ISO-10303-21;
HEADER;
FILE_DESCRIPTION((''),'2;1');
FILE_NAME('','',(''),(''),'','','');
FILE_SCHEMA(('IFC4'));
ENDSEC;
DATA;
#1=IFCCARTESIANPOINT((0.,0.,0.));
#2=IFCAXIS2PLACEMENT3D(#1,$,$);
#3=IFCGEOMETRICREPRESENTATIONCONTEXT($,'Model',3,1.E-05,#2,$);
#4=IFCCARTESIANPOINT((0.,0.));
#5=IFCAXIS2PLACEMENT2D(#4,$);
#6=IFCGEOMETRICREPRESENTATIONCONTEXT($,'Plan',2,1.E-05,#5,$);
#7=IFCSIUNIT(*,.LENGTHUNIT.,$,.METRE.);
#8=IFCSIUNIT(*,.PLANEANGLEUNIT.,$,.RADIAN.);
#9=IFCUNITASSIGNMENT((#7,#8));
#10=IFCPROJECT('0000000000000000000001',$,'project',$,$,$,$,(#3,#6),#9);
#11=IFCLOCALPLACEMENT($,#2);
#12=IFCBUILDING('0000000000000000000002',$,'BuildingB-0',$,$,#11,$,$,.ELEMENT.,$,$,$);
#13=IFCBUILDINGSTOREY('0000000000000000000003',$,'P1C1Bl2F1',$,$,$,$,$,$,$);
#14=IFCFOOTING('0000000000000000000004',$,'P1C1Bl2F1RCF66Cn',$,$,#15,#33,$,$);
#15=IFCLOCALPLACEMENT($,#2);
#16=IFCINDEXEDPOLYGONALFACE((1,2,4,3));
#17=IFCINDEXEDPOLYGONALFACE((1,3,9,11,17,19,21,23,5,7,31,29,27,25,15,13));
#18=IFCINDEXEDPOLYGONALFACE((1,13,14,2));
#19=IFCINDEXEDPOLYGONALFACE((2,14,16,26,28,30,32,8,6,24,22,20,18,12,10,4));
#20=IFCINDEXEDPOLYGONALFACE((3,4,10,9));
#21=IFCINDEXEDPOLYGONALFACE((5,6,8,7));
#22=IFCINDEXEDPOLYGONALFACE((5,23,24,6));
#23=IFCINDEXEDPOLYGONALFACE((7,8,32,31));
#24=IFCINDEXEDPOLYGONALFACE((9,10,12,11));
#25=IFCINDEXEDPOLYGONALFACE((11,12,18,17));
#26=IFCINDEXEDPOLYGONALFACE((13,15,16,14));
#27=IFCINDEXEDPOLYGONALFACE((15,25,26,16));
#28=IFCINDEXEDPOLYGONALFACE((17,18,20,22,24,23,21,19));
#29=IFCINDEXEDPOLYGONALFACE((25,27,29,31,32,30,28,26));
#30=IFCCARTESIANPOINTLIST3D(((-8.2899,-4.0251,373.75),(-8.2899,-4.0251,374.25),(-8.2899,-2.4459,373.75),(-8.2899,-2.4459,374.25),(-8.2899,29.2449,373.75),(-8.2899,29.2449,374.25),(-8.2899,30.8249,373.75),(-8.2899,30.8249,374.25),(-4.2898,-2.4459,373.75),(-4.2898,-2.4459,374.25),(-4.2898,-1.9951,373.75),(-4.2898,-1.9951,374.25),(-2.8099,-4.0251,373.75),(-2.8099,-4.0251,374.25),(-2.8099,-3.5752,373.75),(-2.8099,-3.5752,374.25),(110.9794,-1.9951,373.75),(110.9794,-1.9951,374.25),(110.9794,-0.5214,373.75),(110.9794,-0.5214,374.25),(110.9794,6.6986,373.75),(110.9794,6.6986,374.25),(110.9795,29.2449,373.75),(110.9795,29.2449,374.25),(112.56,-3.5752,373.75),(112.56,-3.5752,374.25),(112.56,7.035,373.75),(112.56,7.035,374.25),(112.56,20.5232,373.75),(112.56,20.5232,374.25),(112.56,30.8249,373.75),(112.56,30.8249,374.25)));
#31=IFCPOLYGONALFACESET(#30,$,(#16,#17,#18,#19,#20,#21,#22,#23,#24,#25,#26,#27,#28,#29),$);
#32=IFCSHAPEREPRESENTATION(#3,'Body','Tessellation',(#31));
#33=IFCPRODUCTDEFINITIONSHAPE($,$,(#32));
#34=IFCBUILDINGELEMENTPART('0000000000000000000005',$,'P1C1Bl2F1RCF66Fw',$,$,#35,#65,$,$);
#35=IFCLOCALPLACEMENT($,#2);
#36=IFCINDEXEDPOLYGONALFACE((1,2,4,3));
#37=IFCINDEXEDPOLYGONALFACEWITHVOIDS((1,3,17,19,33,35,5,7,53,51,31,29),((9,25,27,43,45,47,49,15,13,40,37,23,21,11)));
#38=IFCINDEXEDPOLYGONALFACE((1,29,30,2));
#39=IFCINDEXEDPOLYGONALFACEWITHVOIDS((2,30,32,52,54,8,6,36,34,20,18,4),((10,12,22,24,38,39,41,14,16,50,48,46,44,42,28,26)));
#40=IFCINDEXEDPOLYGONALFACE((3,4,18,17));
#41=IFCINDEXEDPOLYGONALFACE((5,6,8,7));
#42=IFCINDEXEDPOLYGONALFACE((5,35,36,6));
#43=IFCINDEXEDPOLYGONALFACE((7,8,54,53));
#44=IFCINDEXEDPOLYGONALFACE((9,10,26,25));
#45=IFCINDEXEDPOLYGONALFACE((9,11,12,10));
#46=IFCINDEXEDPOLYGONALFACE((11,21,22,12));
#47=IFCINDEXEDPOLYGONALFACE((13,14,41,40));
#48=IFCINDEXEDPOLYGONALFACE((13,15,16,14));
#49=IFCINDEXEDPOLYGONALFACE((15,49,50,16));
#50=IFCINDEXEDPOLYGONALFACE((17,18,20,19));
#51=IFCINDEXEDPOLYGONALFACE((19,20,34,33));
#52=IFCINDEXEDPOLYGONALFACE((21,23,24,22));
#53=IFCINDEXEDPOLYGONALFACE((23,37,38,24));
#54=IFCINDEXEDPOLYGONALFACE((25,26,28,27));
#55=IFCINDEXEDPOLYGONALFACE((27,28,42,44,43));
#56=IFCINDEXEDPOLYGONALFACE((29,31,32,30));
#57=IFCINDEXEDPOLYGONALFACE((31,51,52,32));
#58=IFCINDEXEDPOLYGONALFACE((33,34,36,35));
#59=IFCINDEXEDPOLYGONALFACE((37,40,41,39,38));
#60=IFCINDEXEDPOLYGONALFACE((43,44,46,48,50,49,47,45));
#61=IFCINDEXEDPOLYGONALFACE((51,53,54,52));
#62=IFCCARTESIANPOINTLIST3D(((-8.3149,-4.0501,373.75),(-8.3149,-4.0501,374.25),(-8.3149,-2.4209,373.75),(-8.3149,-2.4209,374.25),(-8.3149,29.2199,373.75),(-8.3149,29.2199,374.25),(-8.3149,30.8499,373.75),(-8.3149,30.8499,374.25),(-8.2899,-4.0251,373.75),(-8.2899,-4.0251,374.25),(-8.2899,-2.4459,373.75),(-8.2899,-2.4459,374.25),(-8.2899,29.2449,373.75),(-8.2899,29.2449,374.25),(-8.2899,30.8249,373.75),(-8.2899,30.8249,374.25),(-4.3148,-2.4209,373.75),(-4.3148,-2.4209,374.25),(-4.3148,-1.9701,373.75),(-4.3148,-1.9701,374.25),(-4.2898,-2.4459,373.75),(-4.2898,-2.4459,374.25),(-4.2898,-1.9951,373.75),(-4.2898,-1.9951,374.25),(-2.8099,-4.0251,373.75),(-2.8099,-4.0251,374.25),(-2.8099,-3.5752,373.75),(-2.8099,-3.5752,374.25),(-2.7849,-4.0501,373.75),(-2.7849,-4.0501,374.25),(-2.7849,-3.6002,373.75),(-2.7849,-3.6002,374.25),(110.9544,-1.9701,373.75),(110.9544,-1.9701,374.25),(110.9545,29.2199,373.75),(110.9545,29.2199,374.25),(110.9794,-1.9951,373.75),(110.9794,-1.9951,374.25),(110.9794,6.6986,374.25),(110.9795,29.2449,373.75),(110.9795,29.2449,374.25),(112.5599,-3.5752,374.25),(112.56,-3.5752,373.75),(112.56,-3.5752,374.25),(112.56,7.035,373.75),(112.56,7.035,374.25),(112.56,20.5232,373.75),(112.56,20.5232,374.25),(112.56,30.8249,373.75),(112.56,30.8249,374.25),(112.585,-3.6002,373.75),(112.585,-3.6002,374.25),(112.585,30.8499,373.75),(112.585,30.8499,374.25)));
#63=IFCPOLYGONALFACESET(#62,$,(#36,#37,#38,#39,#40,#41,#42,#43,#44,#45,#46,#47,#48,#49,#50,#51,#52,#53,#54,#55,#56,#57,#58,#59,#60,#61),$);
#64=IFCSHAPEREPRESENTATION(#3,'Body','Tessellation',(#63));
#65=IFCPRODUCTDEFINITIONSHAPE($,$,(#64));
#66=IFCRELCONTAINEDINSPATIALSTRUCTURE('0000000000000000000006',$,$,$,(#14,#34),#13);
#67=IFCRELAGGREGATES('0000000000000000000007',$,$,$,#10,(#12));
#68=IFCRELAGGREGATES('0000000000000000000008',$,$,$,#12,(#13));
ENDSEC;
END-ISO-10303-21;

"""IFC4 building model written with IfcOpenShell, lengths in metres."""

from ifc_helpers import new_model, si_unit, origin, origin_2d, place, context, project, spatial, polyline, outline, extrude, element, save


model = new_model("IFC4")

# Units and contexts
model_context = context("Model", 3, precision=1e-05, world=origin())
plan_context = context("Plan", 2, precision=1e-05, world=origin_2d())
ifc_project = project(units=[si_unit("LENGTHUNIT", "METRE"), si_unit("PLANEANGLEUNIT", "RADIAN")], contexts=[model_context, plan_context])

# Building, storey
building_placement = place(None, origin())
building = spatial("IfcBuilding", under=ifc_project, at=building_placement, Name="BuildingB-0", CompositionType="ELEMENT")
storey = spatial("IfcBuildingStorey", under=building, Name="P1C1Bl2F1")

# Footing
element("IfcFooting", 1, inside=storey, Name="P1C1Bl2F1RCF66Cn", context=model_context, shape_type="SweptSolid", body=[
    extrude(outline(polyline([(-8.2899, 30.8249, 373.75), (112.56, 30.8249, 373.75), (112.56, 20.5232, 373.75), (112.56, 7.035, 373.75), (112.56, -3.5752, 373.75), (-2.8099, -3.5752, 373.75), (-2.8099, -4.0251, 373.75), (-8.2899, -4.0251, 373.75), (-8.2899, -2.4459, 373.75), (-4.2898, -2.4459, 373.75), (-4.2898, -1.9951, 373.75), (110.9794, -1.9951, 373.75), (110.9794, -0.5214, 373.75), (110.9794, 6.6986, 373.75), (110.9795, 29.2449, 373.75), (-8.2899, 29.2449, 373.75), (-8.2899, 30.8249, 373.75)])), None, (0.0, 0.0, 1.0), 0.5),
])

# Building element part, opening
building_element_part = element("IfcBuildingElementPart", 2, inside=storey, Name="P1C1Bl2F1RCF66Fw", context=model_context, shape_type="SweptSolid", body=[
    extrude(outline(polyline([(-8.3149, 30.8499, 373.75), (112.585, 30.8499, 373.75), (112.585, 20.5232, 373.75), (112.585, 7.035, 373.75), (112.585, -3.6002, 373.75), (-2.7849, -3.6002, 373.75), (-2.7849, -4.0501, 373.75), (-8.3149, -4.0501, 373.75), (-8.3149, -2.4209, 373.75), (-4.3148, -2.4209, 373.75), (-4.3148, -1.9701, 373.75), (110.9544, -1.9701, 373.75), (110.9544, -0.5214, 373.75), (110.9544, 6.6986, 373.75), (110.9545, 29.2199, 373.75), (-8.3149, 29.2199, 373.75), (-8.3149, 30.8499, 373.75)])), None, (0.0, 0.0, 1.0), 0.5),
])
element("IfcOpeningElement", 3, inside=storey, cuts=building_element_part, context=model_context, shape_type="SweptSolid", body=[
    extrude(outline(polyline([(-8.2899, 30.8249, 373.75), (112.56, 30.8249, 373.75), (112.56, 20.5232, 373.75), (112.56, 7.035, 373.75), (112.56, -3.5752, 373.75), (-2.8099, -3.5752, 373.75), (-2.8099, -4.0251, 373.75), (-8.2899, -4.0251, 373.75), (-8.2899, -2.4459, 373.75), (-4.2898, -2.4459, 373.75), (-4.2898, -1.9951, 373.75), (110.9794, -1.9951, 373.75), (110.9794, -0.5214, 373.75), (110.9794, 6.6986, 373.75), (110.9795, 29.2449, 373.75), (-8.2899, 29.2449, 373.75), (-8.2899, 30.8249, 373.75)])), None, (0.0, 0.0, 1.0), 0.5),
])

save(model, "model.ifc")
